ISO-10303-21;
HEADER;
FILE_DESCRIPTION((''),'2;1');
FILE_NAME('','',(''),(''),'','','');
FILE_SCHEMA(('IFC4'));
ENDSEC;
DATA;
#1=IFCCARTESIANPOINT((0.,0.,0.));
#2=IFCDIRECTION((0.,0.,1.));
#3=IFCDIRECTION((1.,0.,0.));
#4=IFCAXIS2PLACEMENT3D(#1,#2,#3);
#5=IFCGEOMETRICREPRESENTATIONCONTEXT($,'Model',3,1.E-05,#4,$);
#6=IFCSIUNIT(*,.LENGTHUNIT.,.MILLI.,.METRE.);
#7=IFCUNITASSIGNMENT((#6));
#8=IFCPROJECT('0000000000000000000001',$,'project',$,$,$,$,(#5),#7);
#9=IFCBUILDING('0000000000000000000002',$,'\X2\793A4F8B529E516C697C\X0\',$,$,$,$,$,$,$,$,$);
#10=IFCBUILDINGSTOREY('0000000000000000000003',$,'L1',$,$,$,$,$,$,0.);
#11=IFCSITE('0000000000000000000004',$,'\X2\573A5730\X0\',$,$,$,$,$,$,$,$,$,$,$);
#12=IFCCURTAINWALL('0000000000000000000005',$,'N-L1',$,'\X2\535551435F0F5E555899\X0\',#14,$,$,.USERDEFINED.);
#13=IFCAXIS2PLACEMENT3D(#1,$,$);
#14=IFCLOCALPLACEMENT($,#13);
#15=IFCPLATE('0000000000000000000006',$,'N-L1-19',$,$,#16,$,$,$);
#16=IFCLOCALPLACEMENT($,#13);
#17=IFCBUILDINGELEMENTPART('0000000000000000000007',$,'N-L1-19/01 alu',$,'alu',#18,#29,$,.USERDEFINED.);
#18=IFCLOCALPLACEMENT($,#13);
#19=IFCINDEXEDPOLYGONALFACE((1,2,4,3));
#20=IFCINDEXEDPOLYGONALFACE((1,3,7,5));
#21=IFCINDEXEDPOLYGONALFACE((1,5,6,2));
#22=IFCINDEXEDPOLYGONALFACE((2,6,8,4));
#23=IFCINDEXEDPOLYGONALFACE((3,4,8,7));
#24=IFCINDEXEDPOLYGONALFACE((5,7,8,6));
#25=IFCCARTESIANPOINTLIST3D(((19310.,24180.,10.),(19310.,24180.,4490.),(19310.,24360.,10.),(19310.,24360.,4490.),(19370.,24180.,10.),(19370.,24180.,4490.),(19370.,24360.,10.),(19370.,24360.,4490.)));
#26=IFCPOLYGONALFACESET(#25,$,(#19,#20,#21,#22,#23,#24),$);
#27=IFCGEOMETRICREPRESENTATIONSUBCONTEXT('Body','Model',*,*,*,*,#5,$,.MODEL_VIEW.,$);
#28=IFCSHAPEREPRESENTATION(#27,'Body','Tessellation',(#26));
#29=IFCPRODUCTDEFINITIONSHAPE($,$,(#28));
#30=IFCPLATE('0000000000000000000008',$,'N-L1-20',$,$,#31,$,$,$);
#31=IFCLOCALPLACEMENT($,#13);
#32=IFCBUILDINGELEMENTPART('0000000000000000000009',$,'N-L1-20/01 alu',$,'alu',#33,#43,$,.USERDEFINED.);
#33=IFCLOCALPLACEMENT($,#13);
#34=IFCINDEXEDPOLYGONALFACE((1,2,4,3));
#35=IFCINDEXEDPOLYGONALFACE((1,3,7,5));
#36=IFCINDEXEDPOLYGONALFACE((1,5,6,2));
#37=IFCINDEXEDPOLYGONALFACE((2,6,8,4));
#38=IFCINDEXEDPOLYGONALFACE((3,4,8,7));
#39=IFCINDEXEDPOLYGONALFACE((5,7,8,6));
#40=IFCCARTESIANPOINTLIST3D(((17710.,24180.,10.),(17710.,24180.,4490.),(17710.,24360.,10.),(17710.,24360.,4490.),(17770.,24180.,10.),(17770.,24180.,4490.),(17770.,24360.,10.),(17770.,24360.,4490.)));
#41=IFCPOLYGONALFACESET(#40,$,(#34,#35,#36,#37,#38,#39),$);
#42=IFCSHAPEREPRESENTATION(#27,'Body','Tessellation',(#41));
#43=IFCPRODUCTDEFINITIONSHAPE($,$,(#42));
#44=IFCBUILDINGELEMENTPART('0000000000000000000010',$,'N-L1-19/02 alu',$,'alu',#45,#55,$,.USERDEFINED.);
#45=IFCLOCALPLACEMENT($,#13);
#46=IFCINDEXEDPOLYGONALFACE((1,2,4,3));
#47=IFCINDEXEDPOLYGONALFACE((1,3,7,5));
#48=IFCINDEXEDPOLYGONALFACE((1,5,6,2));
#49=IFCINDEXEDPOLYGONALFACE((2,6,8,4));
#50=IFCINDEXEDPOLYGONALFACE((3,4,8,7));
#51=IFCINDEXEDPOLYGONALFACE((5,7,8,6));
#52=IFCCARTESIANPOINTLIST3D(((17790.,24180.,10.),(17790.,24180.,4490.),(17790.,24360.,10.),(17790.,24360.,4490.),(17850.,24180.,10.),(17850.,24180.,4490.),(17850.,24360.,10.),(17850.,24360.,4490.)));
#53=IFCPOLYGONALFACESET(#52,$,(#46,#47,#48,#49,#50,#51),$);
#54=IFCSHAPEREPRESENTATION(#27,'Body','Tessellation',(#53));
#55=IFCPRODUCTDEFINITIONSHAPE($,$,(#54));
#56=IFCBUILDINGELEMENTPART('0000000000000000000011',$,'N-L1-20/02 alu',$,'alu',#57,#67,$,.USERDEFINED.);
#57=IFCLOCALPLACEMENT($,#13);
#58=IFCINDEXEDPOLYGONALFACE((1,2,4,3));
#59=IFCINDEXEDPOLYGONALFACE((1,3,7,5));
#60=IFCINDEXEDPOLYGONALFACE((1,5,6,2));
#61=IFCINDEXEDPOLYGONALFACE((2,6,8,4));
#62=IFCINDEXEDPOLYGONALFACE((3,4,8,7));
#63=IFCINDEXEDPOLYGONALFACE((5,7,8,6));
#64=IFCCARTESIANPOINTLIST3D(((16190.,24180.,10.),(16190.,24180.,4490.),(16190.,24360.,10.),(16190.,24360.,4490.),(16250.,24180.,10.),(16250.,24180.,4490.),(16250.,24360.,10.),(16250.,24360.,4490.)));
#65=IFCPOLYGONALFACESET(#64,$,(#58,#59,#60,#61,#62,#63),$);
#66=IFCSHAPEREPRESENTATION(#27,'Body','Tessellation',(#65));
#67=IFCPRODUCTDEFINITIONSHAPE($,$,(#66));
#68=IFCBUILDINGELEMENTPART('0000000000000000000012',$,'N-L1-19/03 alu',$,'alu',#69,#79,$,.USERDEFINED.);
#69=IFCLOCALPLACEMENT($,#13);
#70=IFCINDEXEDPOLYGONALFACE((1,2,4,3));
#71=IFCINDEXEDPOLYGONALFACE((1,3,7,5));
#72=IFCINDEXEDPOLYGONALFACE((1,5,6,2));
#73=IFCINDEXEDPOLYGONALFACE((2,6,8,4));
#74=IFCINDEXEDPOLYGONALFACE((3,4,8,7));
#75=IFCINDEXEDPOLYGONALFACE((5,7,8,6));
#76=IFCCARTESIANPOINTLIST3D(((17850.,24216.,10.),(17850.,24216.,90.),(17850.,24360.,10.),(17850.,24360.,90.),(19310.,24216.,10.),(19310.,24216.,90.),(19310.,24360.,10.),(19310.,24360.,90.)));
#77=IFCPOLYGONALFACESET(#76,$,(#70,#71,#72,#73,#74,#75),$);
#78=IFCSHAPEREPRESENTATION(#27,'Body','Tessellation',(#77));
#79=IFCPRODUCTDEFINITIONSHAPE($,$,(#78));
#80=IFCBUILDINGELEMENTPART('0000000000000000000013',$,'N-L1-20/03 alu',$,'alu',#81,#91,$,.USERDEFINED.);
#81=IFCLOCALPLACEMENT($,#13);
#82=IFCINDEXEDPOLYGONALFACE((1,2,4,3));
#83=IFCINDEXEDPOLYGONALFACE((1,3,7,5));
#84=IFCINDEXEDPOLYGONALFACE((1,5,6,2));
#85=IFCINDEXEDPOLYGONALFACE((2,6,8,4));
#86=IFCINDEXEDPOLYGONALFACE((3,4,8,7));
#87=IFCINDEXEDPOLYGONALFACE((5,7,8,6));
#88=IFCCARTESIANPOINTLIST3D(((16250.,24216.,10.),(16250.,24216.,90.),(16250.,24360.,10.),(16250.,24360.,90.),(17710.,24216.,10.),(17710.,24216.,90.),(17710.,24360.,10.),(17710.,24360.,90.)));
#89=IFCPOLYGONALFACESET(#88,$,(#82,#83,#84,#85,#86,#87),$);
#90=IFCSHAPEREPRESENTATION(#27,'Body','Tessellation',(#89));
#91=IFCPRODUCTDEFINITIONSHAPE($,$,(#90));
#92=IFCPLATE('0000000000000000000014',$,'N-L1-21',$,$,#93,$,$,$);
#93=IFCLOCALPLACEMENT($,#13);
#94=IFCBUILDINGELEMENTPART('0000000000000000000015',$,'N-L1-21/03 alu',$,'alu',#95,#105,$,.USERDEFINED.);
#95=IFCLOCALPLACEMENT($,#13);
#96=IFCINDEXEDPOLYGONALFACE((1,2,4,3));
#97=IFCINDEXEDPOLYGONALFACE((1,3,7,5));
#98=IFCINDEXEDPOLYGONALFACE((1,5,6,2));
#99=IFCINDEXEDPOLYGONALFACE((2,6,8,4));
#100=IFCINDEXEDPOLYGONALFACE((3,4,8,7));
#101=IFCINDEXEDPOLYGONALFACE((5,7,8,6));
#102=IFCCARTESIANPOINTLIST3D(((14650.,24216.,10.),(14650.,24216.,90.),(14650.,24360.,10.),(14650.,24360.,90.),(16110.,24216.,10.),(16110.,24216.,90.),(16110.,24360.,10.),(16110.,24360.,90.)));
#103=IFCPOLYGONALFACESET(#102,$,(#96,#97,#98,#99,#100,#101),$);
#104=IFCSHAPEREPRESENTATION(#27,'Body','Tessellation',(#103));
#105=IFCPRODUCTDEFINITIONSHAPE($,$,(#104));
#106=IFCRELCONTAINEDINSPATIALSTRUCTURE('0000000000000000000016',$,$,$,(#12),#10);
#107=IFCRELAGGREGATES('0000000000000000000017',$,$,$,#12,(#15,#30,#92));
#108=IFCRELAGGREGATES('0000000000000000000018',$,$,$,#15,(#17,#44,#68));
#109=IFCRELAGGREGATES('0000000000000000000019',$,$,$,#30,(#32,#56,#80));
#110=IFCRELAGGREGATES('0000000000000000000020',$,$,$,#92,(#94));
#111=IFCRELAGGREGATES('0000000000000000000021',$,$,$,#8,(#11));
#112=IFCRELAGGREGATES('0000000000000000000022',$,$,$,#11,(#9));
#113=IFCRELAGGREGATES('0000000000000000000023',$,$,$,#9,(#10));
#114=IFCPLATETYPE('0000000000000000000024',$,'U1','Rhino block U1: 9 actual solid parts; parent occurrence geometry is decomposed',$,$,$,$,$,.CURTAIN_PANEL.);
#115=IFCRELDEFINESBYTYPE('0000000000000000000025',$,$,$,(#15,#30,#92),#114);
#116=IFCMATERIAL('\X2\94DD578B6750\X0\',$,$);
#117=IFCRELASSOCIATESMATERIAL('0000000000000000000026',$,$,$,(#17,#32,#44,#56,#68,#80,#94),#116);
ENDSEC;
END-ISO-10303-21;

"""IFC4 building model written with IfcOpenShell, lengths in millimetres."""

from ifc_helpers import new_model, si_unit, frame, frame_2d, origin, origin_with_axes, place, context, subcontext, project, spatial, rectangle, extrude, source, transform, mapped, material, type_object, element, aggregate, save


model = new_model("IFC4")

# Units and contexts
model_context = context("Model", 3, precision=1e-05, world=origin_with_axes())
body_context = subcontext(model_context, "Body", "Model", "MODEL_VIEW")
ifc_project = project(units=[si_unit("LENGTHUNIT", "METRE", prefix="MILLI")], contexts=[model_context])

# Site, building, storey
site = spatial("IfcSite", under=ifc_project, Name="场地")
building = spatial("IfcBuilding", under=site, Name="示例办公楼")
storey = spatial("IfcBuildingStorey", under=building, Name="L1", Elevation=0.0)

# Curtain wall, plates, building element parts
curtain_wall = element("IfcCurtainWall", 1, inside=storey, Name="N-L1", ObjectType="单元式幕墙", PredefinedType="USERDEFINED")
plate_type = type_object("IfcPlateType", Name="U1", Description="Rhino block U1: 9 actual solid parts; parent occurrence geometry is decomposed", PredefinedType="CURTAIN_PANEL")
plate_1_placement = place(None, frame((19370.0, 24360.0, 10.0), z_axis=(0.0, 0.0, 1.0), x_axis=(-1.0, 0.0, 0.0)))
plate_1 = element("IfcPlate", 2, at=plate_1_placement, type_object=plate_type, Name="N-L1-19")
ifc_material_1 = material(Name="铝型材")
shared_shape_1 = source(origin(), body_context, "Body", "SweptSolid", [
    extrude(rectangle(XDim=60.0, YDim=180.0, at=frame_2d((30.0, 90.0))), origin(), (0.0, 0.0, 1.0), 4480.0),
])
building_element_part_1_placement = place(plate_1_placement, origin())
building_element_part_1 = element("IfcBuildingElementPart", 3, at=building_element_part_1_placement, material=ifc_material_1, Name="N-L1-19/01 alu", ObjectType="alu", PredefinedType="USERDEFINED", context=body_context, shape_type="MappedRepresentation", body=[
    mapped(shared_shape_1, transform((0.0, 0.0, 0.0))),
])
plate_2_placement = place(None, frame((17770.0, 24360.0, 10.0), z_axis=(0.0, 0.0, 1.0), x_axis=(-1.0, 0.0, 0.0)))
plate_2 = element("IfcPlate", 4, at=plate_2_placement, type_object=plate_type, Name="N-L1-20")
building_element_part_2_placement = place(plate_2_placement, origin())
building_element_part_2 = element("IfcBuildingElementPart", 5, at=building_element_part_2_placement, material=ifc_material_1, Name="N-L1-20/01 alu", ObjectType="alu", PredefinedType="USERDEFINED", context=body_context, shape_type="MappedRepresentation", body=[
    mapped(shared_shape_1, transform((0.0, 0.0, 0.0))),
])
shared_shape_2 = source(origin(), body_context, "Body", "SweptSolid", [
    extrude(rectangle(XDim=60.0, YDim=180.0, at=frame_2d((1550.0, 90.0))), origin(), (0.0, 0.0, 1.0), 4480.0),
])
building_element_part_3_placement = place(plate_1_placement, origin())
building_element_part_3 = element("IfcBuildingElementPart", 6, at=building_element_part_3_placement, material=ifc_material_1, Name="N-L1-19/02 alu", ObjectType="alu", PredefinedType="USERDEFINED", context=body_context, shape_type="MappedRepresentation", body=[
    mapped(shared_shape_2, transform((0.0, 0.0, 0.0))),
])
building_element_part_4_placement = place(plate_2_placement, origin())
building_element_part_4 = element("IfcBuildingElementPart", 7, at=building_element_part_4_placement, material=ifc_material_1, Name="N-L1-20/02 alu", ObjectType="alu", PredefinedType="USERDEFINED", context=body_context, shape_type="MappedRepresentation", body=[
    mapped(shared_shape_2, transform((0.0, 0.0, 0.0))),
])
shared_shape_3 = source(origin(), body_context, "Body", "SweptSolid", [
    extrude(rectangle(XDim=1460.0, YDim=144.0, at=frame_2d((790.0, 72.0))), origin(), (0.0, 0.0, 1.0), 80.0),
])
building_element_part_5_placement = place(plate_1_placement, origin())
building_element_part_5 = element("IfcBuildingElementPart", 8, at=building_element_part_5_placement, material=ifc_material_1, Name="N-L1-19/03 alu", ObjectType="alu", PredefinedType="USERDEFINED", context=body_context, shape_type="MappedRepresentation", body=[
    mapped(shared_shape_3, transform((0.0, 0.0, 0.0))),
])
building_element_part_6_placement = place(plate_2_placement, origin())
building_element_part_6 = element("IfcBuildingElementPart", 9, at=building_element_part_6_placement, material=ifc_material_1, Name="N-L1-20/03 alu", ObjectType="alu", PredefinedType="USERDEFINED", context=body_context, shape_type="MappedRepresentation", body=[
    mapped(shared_shape_3, transform((0.0, 0.0, 0.0))),
])
plate_3_placement = place(None, frame((16170.0, 24360.0, 10.0), z_axis=(0.0, 0.0, 1.0), x_axis=(-1.0, 0.0, 0.0)))
plate_3 = element("IfcPlate", 10, at=plate_3_placement, type_object=plate_type, Name="N-L1-21")
aggregate(curtain_wall, [plate_1, plate_2, plate_3])
building_element_part_7_placement = place(plate_3_placement, origin())
building_element_part_7 = element("IfcBuildingElementPart", 11, at=building_element_part_7_placement, material=ifc_material_1, Name="N-L1-21/03 alu", ObjectType="alu", PredefinedType="USERDEFINED", context=body_context, shape_type="MappedRepresentation", body=[
    mapped(shared_shape_3, transform((0.0, 0.0, 0.0))),
])
aggregate(plate_1, [building_element_part_1, building_element_part_3, building_element_part_5])
aggregate(plate_2, [building_element_part_2, building_element_part_4, building_element_part_6])
aggregate(plate_3, [building_element_part_7])

save(model, "model.ifc")
